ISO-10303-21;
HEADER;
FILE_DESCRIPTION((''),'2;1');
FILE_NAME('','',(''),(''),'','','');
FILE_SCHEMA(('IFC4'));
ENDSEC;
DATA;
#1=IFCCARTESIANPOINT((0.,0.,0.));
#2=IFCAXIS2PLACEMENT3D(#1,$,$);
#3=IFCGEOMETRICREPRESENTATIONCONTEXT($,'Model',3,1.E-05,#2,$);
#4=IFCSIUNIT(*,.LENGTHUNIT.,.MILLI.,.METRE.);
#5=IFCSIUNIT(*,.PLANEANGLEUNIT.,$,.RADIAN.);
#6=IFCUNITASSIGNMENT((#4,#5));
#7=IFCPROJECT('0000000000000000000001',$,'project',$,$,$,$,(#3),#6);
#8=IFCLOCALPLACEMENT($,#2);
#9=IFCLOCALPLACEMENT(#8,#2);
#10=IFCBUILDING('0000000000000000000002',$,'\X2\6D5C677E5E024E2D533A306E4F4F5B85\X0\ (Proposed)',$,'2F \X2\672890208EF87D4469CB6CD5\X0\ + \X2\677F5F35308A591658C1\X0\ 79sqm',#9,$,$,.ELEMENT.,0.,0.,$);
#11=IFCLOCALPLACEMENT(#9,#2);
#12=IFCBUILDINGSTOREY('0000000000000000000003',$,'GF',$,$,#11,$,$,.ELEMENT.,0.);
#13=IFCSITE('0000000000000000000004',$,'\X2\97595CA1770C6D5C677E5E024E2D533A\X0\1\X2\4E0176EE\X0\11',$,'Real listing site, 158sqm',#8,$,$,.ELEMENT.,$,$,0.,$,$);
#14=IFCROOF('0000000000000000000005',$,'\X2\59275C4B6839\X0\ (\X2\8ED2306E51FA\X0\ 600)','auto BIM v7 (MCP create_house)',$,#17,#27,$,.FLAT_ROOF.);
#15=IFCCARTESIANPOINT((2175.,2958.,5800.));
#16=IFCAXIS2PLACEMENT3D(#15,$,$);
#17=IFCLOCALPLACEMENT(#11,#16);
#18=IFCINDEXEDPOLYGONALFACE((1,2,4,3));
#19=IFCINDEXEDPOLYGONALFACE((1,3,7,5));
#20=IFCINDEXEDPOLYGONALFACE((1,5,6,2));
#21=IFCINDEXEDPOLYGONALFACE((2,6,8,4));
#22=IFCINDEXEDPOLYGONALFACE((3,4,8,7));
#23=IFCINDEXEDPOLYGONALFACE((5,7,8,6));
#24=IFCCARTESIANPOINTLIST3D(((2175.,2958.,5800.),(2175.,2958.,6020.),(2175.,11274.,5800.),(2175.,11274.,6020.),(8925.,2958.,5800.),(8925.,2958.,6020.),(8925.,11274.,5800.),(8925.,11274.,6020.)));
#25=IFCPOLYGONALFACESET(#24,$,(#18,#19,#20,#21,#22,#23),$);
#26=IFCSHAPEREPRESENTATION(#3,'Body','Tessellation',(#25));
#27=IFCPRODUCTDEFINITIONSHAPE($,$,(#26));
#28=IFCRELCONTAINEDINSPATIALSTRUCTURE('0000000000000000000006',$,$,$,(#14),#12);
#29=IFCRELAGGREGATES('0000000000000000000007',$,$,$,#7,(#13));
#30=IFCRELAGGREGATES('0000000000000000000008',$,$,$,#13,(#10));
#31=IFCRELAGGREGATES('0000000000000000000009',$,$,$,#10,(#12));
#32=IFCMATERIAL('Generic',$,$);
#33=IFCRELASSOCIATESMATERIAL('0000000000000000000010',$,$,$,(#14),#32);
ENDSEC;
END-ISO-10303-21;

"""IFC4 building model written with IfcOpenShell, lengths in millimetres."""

from ifc_helpers import new_model, si_unit, frame, frame_2d, origin, place, context, project, spatial, rectangle, extrude, material, element, save


model = new_model("IFC4")

# Units and contexts
model_context = context("Model", 3, precision=1e-05, world=origin())
ifc_project = project(units=[si_unit("LENGTHUNIT", "METRE", prefix="MILLI"), si_unit("PLANEANGLEUNIT", "RADIAN")], contexts=[model_context])

# Site, building, storey
site_placement = place(None, origin())
site = spatial("IfcSite", under=ifc_project, at=site_placement, Name="静岡県浜松市中区1丁目11", ObjectType="Real listing site, 158sqm", CompositionType="ELEMENT", RefElevation=0.0)
building_placement = place(site_placement, origin())
building = spatial("IfcBuilding", under=site, at=building_placement, Name="浜松市中区の住宅 (Proposed)", ObjectType="2F 木造軸組構法 + 板張り外壁 79sqm", CompositionType="ELEMENT", ElevationOfRefHeight=0.0, ElevationOfTerrain=0.0)
storey_placement = place(building_placement, origin())
storey = spatial("IfcBuildingStorey", under=building, at=storey_placement, Name="GF", CompositionType="ELEMENT", Elevation=0.0)

# Shared definitions
ifc_material = material(Name="Generic")

# Roof
roof_placement = place(storey_placement, frame((2175.0, 2958.0, 5800.0)))
element("IfcRoof", 1, at=roof_placement, inside=storey, material=ifc_material, Name="大屋根 (軒の出 600)", Description="auto BIM v7 (MCP create_house)", PredefinedType="FLAT_ROOF", context=model_context, shape_type="SweptSolid", body=[
    extrude(rectangle(XDim=6750.0, YDim=8316.0, at=frame_2d((3375.0, 4158.0))), frame((2175.0, 2958.0, 5800.0)), (0.0, 0.0, 1.0), 220.0),
])

save(model, "model.ifc")
